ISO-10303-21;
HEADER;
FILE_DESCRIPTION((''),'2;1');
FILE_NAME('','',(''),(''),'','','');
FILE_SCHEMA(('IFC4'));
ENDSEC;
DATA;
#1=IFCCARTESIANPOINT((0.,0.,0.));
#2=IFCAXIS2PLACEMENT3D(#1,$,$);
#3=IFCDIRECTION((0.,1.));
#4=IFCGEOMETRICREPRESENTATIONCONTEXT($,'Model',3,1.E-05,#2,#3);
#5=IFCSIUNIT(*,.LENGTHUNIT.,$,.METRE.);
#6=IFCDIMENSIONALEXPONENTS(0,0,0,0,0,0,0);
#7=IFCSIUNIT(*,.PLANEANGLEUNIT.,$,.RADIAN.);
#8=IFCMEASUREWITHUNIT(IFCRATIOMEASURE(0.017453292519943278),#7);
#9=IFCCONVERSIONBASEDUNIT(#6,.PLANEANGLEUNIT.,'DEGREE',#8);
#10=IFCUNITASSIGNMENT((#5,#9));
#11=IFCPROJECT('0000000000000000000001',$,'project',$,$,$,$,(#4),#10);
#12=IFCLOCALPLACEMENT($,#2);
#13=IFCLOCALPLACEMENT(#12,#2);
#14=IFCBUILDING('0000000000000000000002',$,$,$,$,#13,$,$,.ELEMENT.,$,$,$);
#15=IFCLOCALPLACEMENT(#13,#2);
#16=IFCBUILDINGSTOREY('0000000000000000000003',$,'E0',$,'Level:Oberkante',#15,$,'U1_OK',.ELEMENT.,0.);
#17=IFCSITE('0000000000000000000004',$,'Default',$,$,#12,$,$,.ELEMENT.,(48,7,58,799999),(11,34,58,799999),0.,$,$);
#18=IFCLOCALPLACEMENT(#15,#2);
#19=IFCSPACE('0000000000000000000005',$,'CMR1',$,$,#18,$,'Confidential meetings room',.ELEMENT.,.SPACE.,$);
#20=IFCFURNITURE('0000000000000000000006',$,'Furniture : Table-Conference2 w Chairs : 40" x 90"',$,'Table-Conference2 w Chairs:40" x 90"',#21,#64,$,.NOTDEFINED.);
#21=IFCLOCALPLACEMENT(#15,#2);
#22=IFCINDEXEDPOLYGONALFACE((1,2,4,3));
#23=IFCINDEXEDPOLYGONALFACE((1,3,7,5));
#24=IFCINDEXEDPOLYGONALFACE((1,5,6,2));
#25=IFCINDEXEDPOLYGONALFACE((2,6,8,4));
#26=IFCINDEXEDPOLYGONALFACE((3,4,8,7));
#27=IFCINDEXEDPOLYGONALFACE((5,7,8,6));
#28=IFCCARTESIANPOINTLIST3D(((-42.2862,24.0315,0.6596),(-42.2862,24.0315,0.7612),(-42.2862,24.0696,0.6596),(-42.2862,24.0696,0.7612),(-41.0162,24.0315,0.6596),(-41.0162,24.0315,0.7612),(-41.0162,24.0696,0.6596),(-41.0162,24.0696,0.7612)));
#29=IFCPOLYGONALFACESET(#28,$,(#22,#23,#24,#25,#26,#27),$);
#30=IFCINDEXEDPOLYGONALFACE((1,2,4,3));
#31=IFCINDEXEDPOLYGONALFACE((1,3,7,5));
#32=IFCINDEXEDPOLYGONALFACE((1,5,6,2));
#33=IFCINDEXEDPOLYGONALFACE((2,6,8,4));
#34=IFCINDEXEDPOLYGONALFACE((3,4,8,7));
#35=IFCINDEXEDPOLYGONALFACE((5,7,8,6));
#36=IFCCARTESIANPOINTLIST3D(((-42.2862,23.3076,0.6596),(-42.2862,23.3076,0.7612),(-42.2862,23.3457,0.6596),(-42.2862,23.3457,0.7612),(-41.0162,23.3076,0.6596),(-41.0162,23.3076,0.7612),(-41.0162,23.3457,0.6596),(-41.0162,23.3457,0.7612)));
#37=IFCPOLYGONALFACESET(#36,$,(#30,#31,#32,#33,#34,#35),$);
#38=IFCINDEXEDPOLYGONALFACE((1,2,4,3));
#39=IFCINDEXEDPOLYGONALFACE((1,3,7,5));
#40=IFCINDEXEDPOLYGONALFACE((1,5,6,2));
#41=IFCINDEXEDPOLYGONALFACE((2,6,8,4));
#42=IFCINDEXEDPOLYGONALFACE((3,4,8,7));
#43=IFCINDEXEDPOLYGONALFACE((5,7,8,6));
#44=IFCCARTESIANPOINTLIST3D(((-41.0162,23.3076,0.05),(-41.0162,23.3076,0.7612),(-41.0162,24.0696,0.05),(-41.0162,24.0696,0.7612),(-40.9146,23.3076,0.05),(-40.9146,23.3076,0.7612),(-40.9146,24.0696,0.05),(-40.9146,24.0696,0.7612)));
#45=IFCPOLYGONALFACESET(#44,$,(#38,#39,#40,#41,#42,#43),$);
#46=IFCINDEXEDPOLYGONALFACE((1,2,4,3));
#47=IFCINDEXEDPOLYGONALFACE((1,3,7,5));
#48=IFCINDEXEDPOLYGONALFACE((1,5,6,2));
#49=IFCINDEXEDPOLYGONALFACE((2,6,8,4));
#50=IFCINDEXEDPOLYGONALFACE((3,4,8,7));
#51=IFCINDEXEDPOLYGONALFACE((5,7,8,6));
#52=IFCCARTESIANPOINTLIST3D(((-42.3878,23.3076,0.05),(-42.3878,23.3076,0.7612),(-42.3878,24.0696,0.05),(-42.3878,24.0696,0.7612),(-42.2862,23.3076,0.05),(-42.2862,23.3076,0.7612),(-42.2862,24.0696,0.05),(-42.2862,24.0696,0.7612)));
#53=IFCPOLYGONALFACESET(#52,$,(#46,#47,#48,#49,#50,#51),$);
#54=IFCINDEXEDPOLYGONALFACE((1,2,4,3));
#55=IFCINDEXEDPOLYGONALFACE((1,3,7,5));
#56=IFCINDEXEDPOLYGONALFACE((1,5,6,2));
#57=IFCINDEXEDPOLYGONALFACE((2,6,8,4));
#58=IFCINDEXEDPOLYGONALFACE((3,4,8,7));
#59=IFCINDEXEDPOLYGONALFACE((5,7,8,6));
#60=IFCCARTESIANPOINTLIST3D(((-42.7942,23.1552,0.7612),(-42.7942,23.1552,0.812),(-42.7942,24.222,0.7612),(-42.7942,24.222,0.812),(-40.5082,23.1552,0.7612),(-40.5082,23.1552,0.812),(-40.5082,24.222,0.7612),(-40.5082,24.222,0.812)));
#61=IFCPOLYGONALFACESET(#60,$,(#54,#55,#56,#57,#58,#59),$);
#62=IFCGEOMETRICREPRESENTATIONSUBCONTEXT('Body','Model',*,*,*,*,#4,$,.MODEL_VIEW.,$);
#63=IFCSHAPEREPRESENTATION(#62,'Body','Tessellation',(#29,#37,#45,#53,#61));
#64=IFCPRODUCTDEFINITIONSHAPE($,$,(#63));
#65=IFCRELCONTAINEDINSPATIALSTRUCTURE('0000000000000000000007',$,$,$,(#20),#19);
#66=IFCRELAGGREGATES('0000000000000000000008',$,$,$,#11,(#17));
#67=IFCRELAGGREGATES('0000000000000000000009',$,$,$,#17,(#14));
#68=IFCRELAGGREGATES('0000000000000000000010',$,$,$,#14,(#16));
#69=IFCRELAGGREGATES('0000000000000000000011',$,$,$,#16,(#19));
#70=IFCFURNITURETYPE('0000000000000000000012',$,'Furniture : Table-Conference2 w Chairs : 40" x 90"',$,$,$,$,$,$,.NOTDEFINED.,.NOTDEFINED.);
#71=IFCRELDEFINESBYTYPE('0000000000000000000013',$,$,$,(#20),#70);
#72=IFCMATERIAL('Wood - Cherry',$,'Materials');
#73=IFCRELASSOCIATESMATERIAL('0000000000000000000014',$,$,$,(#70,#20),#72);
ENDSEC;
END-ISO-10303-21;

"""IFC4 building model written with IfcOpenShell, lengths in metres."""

from ifc_helpers import new_model, entity, si_unit, converted_unit, direction, frame, origin, place, context, subcontext, project, spatial, indexed_curve, outline, extrude, source, transform, mapped, material, type_object, type_shapes, element, save


model = new_model("IFC4")

# Units and contexts
model_context = context("Model", 3, precision=1e-05, world=origin(), true_north=direction((0.0, 1.0)))
body_context = subcontext(model_context, "Body", "Model", "MODEL_VIEW")
ifc_project = project(units=[si_unit("LENGTHUNIT", "METRE"), converted_unit("PLANEANGLEUNIT", "DEGREE", entity("IfcRatioMeasure", 0.017453292519943278), si_unit("PLANEANGLEUNIT", "RADIAN"), dimensions=[0, 0, 0, 0, 0, 0, 0])], contexts=[model_context])

# Site, building, storey
site_placement = place(None, origin())
site = spatial("IfcSite", under=ifc_project, at=site_placement, Name="Default", CompositionType="ELEMENT", RefLatitude=(48, 7, 58, 799999), RefLongitude=(11, 34, 58, 799999), RefElevation=0.0)
building_placement = place(site_placement, origin())
building = spatial("IfcBuilding", under=site, at=building_placement, CompositionType="ELEMENT")
storey_placement = place(building_placement, origin())
storey = spatial("IfcBuildingStorey", under=building, at=storey_placement, Name="E0", ObjectType="Level:Oberkante", LongName="U1_OK", CompositionType="ELEMENT", Elevation=0.0)

# Shared definitions
space_1_placement = place(storey_placement, origin())
space_1 = spatial("IfcSpace", under=storey, at=space_1_placement, Name="CMR1", LongName="Confidential meetings room", CompositionType="ELEMENT", PredefinedType="SPACE")

# Furniture
ifc_material_1 = material(Name="Wood - Cherry", Category="Materials")
furniture_type_1 = type_object("IfcFurnitureType", Name="Furniture : Table-Conference2 w Chairs : 40\" x 90\"", AssemblyPlace="NOTDEFINED", PredefinedType="NOTDEFINED", material=ifc_material_1)
shared_shape_1 = source(origin(), body_context, "Body", "SweptSolid", [
    extrude(outline(indexed_curve([(-0.635, -0.0191), (0.635, -0.0191), (0.635, 0.0191), (-0.635, 0.0191), (-0.635, -0.0191)], self_intersect=False)), frame((0.0, 0.362, 0.6096), z_axis=(0.0, 0.0, 1.0), x_axis=(-1.0, 0.0, 0.0)), (0.0, 0.0, 1.0), 0.1016),
    extrude(outline(indexed_curve([(-0.019, -0.635), (0.019, -0.635), (0.019, 0.635), (-0.019, 0.635), (-0.019, -0.635)], self_intersect=False)), frame((0.0, -0.362, 0.6096), z_axis=(0.0, 0.0, 1.0), x_axis=(0.0, 1.0, 0.0)), (0.0, 0.0, 1.0), 0.1016),
    extrude(outline(indexed_curve([(-0.381, -0.0508), (0.381, -0.0508), (0.381, 0.0508), (-0.381, 0.0508), (-0.381, -0.0508)], self_intersect=False)), frame((0.6858, 0.0, 0.0), z_axis=(0.0, 0.0, 1.0), x_axis=(0.0, 1.0, 0.0)), (0.0, 0.0, 1.0), 0.7112),
    extrude(outline(indexed_curve([(-0.381, -0.0508), (0.381, -0.0508), (0.381, 0.0508), (-0.381, 0.0508), (-0.381, -0.0508)], self_intersect=False)), frame((-0.6858, 0.0, 0.0), z_axis=(0.0, 0.0, 1.0), x_axis=(0.0, 1.0, 0.0)), (0.0, 0.0, 1.0), 0.7112),
    extrude(outline(indexed_curve([(-0.5334, -1.143), (0.5334, -1.143), (0.5334, 1.143), (-0.5334, 1.143), (-0.5334, -1.143)], self_intersect=False)), frame((0.0, 0.0, 0.7112), z_axis=(0.0, 0.0, 1.0), x_axis=(0.0, 1.0, 0.0)), (0.0, 0.0, 1.0), 0.0508),
])
type_shapes(furniture_type_1, [shared_shape_1])
furniture_1_placement = place(space_1_placement, frame((-41.6512, 23.6886, 0.05)))
element("IfcFurniture", 1, at=furniture_1_placement, inside=space_1, type_object=furniture_type_1, material=ifc_material_1, Name="Furniture : Table-Conference2 w Chairs : 40\" x 90\"", ObjectType="Table-Conference2 w Chairs:40\" x 90\"", PredefinedType="NOTDEFINED", context=body_context, shape_type="MappedRepresentation", body=[
    mapped(shared_shape_1, transform((0.0, 0.0, 0.0), scale=1.0)),
])

save(model, "model.ifc")
